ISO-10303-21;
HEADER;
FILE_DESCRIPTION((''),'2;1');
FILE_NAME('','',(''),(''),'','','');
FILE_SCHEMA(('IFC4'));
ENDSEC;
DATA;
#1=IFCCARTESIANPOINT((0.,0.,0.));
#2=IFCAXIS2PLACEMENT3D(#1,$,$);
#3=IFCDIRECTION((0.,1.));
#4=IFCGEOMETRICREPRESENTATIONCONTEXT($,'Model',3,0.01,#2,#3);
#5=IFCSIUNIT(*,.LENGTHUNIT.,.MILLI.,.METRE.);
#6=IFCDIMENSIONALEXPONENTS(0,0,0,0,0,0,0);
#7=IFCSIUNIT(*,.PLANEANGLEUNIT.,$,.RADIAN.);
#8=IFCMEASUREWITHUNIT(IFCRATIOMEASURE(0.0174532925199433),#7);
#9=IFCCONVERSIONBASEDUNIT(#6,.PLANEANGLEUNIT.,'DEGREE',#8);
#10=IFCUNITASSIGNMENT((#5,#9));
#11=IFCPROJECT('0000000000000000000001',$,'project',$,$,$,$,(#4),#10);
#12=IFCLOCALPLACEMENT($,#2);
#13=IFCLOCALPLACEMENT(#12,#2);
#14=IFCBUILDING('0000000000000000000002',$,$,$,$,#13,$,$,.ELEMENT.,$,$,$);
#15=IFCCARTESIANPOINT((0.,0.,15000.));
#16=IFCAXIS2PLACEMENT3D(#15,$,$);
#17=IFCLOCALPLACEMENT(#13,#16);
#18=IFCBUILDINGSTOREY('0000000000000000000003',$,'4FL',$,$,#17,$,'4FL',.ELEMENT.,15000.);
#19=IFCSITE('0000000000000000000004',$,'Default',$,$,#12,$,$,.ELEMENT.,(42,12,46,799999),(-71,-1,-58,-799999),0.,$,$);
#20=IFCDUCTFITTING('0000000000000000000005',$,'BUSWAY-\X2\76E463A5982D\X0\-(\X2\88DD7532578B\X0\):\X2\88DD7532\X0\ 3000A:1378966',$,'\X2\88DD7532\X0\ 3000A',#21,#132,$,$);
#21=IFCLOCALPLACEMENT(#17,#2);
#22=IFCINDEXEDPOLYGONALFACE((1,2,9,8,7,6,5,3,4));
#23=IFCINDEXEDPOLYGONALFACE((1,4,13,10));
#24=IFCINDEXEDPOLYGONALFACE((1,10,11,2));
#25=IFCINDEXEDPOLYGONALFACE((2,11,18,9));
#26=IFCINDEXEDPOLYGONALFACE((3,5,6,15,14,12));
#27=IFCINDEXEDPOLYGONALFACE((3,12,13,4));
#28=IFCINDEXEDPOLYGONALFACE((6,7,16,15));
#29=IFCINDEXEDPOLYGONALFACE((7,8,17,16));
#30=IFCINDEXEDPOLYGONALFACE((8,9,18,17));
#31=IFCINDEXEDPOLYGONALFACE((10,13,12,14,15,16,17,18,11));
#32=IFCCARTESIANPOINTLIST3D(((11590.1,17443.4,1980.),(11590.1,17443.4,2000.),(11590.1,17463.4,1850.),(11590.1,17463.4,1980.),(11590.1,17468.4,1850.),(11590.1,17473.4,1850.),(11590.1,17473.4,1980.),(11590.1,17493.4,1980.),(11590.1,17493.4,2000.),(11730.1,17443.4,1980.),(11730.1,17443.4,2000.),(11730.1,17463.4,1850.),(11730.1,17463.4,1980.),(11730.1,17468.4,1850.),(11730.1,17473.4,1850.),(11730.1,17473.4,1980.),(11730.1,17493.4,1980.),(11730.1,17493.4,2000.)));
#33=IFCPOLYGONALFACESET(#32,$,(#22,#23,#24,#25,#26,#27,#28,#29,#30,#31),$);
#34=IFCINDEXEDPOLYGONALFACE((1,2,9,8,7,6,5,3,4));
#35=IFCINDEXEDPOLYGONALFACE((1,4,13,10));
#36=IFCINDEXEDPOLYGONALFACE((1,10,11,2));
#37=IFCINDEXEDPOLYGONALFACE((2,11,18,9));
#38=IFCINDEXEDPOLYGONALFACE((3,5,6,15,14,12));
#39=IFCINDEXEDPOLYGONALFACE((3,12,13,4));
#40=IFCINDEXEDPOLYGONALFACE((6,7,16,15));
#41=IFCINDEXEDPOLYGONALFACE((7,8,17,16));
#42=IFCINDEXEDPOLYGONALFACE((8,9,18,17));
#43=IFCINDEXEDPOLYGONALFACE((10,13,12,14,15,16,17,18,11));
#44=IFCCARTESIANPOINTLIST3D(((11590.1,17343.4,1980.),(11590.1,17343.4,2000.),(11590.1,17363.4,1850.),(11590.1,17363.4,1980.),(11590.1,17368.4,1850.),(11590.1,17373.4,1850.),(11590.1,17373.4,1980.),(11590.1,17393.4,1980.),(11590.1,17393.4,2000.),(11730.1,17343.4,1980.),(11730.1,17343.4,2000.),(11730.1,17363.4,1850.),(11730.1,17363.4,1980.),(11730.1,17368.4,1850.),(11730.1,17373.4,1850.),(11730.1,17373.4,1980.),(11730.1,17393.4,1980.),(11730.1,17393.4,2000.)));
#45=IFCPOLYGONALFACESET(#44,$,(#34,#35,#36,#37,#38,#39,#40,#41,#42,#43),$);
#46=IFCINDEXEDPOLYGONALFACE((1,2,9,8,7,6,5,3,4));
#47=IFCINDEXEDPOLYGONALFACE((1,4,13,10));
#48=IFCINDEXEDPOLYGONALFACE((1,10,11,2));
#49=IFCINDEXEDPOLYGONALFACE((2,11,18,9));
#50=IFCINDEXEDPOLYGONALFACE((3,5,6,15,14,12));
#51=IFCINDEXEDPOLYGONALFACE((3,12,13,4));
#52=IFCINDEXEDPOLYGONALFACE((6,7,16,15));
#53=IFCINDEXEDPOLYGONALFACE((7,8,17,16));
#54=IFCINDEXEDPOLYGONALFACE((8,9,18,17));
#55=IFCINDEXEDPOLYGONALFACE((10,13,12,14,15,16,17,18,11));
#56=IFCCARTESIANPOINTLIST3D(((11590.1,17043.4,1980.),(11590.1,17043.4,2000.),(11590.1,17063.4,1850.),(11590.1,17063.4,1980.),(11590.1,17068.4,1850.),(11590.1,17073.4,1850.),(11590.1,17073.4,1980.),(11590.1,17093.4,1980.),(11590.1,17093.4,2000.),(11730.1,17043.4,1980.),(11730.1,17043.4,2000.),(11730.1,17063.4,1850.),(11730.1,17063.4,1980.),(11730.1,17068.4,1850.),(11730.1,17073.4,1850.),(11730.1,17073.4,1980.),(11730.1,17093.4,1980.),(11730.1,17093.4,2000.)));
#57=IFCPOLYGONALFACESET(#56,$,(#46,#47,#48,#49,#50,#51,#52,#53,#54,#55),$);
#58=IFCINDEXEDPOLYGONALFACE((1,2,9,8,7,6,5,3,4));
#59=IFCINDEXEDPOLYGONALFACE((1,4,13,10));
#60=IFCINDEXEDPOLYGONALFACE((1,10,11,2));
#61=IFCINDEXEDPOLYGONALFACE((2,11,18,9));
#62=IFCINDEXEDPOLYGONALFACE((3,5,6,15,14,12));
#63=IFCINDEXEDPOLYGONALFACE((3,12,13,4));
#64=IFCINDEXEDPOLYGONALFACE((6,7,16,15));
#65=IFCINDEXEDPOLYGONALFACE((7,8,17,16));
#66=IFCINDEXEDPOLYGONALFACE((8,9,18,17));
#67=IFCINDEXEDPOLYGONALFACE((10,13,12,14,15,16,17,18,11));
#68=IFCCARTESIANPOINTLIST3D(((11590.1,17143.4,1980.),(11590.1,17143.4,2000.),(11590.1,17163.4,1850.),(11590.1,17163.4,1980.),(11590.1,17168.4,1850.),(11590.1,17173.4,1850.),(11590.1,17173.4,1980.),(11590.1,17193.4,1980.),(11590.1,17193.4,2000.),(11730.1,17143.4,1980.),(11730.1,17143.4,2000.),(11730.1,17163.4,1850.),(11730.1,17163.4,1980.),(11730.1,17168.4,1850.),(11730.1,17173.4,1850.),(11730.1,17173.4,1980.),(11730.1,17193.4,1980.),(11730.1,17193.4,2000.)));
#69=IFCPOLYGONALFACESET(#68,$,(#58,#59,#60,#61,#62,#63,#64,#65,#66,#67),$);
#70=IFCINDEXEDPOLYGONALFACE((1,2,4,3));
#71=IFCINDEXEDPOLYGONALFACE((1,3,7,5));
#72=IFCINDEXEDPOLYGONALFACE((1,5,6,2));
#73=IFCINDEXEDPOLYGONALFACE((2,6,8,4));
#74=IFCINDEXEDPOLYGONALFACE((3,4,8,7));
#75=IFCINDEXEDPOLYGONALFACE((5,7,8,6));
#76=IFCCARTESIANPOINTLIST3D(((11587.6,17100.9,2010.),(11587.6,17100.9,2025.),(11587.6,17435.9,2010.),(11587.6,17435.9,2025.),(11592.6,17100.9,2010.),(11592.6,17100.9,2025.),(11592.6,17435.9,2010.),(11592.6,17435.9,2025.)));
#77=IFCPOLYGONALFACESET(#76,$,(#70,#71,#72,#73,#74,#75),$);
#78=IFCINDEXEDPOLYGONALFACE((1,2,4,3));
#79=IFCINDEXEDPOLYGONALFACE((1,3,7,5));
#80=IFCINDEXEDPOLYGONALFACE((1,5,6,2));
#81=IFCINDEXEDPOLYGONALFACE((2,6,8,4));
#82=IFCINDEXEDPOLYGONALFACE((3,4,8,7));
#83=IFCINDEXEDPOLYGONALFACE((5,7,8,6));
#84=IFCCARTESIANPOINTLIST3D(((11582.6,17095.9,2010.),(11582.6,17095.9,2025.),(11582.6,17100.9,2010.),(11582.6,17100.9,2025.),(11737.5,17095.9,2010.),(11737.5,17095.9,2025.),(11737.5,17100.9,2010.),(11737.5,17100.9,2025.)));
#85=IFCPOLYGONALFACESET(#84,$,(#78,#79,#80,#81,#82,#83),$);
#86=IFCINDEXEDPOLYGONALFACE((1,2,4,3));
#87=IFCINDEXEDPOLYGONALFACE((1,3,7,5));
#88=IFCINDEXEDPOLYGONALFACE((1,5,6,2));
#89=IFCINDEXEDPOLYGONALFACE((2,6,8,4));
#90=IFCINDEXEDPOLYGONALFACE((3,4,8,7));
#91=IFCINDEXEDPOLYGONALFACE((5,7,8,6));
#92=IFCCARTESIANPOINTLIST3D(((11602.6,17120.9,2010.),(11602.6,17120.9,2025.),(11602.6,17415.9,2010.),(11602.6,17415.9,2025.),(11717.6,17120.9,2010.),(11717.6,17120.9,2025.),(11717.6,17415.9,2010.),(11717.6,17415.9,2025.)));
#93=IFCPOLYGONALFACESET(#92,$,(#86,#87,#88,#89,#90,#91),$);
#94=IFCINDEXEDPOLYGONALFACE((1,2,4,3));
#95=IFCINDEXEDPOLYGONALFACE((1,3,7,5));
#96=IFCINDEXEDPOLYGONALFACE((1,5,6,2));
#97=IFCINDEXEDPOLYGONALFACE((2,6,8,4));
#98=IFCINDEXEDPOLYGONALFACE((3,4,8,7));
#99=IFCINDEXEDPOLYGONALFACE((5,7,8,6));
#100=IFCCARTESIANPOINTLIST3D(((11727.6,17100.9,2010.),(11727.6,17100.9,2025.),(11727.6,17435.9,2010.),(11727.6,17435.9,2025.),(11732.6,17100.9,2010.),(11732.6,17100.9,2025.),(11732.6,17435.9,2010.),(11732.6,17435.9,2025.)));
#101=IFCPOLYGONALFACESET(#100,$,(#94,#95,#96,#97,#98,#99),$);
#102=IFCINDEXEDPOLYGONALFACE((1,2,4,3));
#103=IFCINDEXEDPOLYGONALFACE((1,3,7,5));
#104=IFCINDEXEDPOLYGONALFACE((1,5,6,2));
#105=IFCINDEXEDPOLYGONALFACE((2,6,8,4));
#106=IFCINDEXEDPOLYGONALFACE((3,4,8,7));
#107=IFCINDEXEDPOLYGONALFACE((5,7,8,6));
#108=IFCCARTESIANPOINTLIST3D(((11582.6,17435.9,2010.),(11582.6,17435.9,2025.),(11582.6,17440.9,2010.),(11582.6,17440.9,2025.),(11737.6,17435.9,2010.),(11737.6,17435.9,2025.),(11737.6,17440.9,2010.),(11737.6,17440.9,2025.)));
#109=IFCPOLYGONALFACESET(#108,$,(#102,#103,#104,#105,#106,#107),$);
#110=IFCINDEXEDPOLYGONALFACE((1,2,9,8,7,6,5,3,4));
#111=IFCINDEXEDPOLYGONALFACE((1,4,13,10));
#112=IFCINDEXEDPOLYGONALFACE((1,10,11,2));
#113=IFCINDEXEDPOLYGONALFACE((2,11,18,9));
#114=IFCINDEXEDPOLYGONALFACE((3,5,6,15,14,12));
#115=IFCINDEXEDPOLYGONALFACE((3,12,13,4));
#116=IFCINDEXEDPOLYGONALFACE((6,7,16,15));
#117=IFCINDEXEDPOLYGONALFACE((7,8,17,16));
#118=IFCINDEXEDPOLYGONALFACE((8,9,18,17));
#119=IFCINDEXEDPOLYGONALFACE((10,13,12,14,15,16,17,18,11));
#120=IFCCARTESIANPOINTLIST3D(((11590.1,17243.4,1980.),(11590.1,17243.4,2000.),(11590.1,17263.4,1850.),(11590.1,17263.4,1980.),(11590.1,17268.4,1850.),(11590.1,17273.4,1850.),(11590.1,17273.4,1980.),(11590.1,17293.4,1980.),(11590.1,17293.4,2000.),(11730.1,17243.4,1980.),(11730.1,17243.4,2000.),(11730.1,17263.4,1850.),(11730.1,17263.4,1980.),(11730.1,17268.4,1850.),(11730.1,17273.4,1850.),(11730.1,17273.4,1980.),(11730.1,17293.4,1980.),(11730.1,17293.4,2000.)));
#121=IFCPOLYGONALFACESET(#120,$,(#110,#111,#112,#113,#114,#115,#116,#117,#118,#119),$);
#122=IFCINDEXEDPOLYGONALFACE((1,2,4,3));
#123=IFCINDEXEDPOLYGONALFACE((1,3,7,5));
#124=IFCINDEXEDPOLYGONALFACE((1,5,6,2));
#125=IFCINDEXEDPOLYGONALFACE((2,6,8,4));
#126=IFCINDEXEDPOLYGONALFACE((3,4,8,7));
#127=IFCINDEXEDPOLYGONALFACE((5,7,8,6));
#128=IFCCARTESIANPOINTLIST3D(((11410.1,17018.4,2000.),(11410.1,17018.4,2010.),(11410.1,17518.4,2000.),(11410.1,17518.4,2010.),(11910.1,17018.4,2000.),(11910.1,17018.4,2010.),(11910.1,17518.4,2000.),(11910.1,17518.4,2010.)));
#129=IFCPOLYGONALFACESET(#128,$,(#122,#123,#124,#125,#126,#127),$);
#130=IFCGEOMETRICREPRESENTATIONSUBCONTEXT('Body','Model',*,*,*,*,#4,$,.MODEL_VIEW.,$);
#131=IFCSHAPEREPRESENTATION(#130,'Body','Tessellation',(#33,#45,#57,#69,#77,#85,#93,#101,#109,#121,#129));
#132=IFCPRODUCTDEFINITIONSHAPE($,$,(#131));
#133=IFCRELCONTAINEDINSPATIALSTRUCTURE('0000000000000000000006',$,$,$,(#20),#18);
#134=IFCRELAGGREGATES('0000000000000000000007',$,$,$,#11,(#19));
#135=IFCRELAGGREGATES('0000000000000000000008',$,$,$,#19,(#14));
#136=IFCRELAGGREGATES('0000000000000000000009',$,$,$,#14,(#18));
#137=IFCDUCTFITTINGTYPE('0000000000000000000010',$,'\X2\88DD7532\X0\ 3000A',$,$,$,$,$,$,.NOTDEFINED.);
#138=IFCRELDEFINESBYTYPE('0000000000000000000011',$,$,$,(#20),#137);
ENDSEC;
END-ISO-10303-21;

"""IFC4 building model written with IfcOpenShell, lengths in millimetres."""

from ifc_helpers import new_model, entity, si_unit, converted_unit, direction, frame, frame_2d, origin, origin_2d_with_axis, place, context, subcontext, project, spatial, polyline, rectangle, outline, extrude, source, transform, mapped, type_object, type_shapes, element, save


model = new_model("IFC4")

# Units and contexts
model_context = context("Model", 3, precision=0.01, world=origin(), true_north=direction((0.0, 1.0)))
body_context = subcontext(model_context, "Body", "Model", "MODEL_VIEW")
ifc_project = project(units=[si_unit("LENGTHUNIT", "METRE", prefix="MILLI"), converted_unit("PLANEANGLEUNIT", "DEGREE", entity("IfcRatioMeasure", 0.0174532925199433), si_unit("PLANEANGLEUNIT", "RADIAN"), dimensions=[0, 0, 0, 0, 0, 0, 0])], contexts=[model_context])

# Site, building, storey
site_placement = place(None, origin())
site = spatial("IfcSite", under=ifc_project, at=site_placement, Name="Default", CompositionType="ELEMENT", RefLatitude=(42, 12, 46, 799999), RefLongitude=(-71, -1, -58, -799999), RefElevation=0.0)
building_placement = place(site_placement, origin())
building = spatial("IfcBuilding", under=site, at=building_placement, CompositionType="ELEMENT")
storey_placement = place(building_placement, frame((0.0, 0.0, 15000.0)))
storey = spatial("IfcBuildingStorey", under=building, at=storey_placement, Name="4FL", LongName="4FL", CompositionType="ELEMENT", Elevation=15000.0)

# Duct fitting
duct_fitting_type_1 = type_object("IfcDuctFittingType", Name="裝甲 3000A", PredefinedType="NOTDEFINED")
shared_shape_1 = source(origin(), body_context, "Body", "SweptSolid", [
    extrude(outline(polyline([(-25.0, -58.9), (25.0, -58.9), (25.0, -38.9), (5.0, -38.9), (5.0, 91.1), (0.0, 91.1), (-5.0, 91.1), (-5.0, -38.9), (-25.0, -38.9), (-25.0, -58.9)])), frame((-200.0, -70.0, -58.9), z_axis=(0.0, 1.0, 0.0), x_axis=(1.0, 0.0, 0.0)), (0.0, 0.0, 1.0), 140.0),
    extrude(outline(polyline([(-25.0, -58.9), (25.0, -58.9), (25.0, -38.9), (5.0, -38.9), (5.0, 91.1), (0.0, 91.1), (-5.0, 91.1), (-5.0, -38.9), (-25.0, -38.9), (-25.0, -58.9)])), frame((-100.0, -70.0, -58.9), z_axis=(0.0, 1.0, 0.0), x_axis=(1.0, 0.0, 0.0)), (0.0, 0.0, 1.0), 140.0),
    extrude(outline(polyline([(-58.9, -25.0), (-38.9, -25.0), (-38.9, -5.0), (91.1, -5.0), (91.1, 0.0), (91.1, 5.0), (-38.9, 5.0), (-38.9, 25.0), (-58.9, 25.0), (-58.9, -25.0)])), frame((200.0, -70.0, -58.9), z_axis=(0.0, 1.0, 0.0), x_axis=(0.0, 0.0, -1.0)), (0.0, 0.0, 1.0), 140.0),
    extrude(outline(polyline([(-58.9, -25.0), (-38.9, -25.0), (-38.9, -5.0), (91.1, -5.0), (91.1, 0.0), (91.1, 5.0), (-38.9, 5.0), (-38.9, 25.0), (-58.9, 25.0), (-58.9, -25.0)])), frame((100.0, -70.0, -58.9), z_axis=(0.0, 1.0, 0.0), x_axis=(0.0, 0.0, -1.0)), (0.0, 0.0, 1.0), 140.0),
    extrude(rectangle(XDim=335.0, YDim=5.0, at=origin_2d_with_axis()), frame((0.0, -70.0, 10.0), z_axis=(0.0, 0.0, 1.0), x_axis=(-1.0, 0.0, 0.0)), (0.0, 0.0, 1.0), 15.0),
    extrude(rectangle(XDim=5.0, YDim=154.9, at=frame_2d((0.0, 0.0), x_axis=(1.0, 0.0))), frame((170.0, -0.1, 10.0), z_axis=(0.0, 0.0, 1.0), x_axis=(-1.0, 0.0, 0.0)), (0.0, 0.0, 1.0), 15.0),
    extrude(rectangle(XDim=295.0, YDim=115.0, at=origin_2d_with_axis()), frame((0.0, 0.0, 10.0), z_axis=(0.0, 0.0, 1.0), x_axis=(-1.0, 0.0, 0.0)), (0.0, 0.0, 1.0), 15.0),
    extrude(rectangle(XDim=335.0, YDim=5.0, at=origin_2d_with_axis()), frame((0.0, 70.0, 10.0), z_axis=(0.0, 0.0, 1.0), x_axis=(-1.0, 0.0, 0.0)), (0.0, 0.0, 1.0), 15.0),
    extrude(rectangle(XDim=5.0, YDim=155.0, at=origin_2d_with_axis()), frame((-170.0, 0.0, 10.0), z_axis=(0.0, 0.0, 1.0), x_axis=(-1.0, 0.0, 0.0)), (0.0, 0.0, 1.0), 15.0),
    extrude(outline(polyline([(-58.9, -25.0), (-38.9, -25.0), (-38.9, -5.0), (91.1, -5.0), (91.1, 0.0), (91.1, 5.0), (-38.9, 5.0), (-38.9, 25.0), (-58.9, 25.0), (-58.9, -25.0)])), frame((0.0, -70.0, -58.9), z_axis=(0.0, 1.0, 0.0), x_axis=(0.0, 0.0, -1.0)), (0.0, 0.0, 1.0), 140.0),
    extrude(rectangle(XDim=500.0, YDim=500.0, at=origin_2d_with_axis()), frame((0.0, 0.0, 0.0), z_axis=(0.0, 0.0, 1.0), x_axis=(0.0, 1.0, 0.0)), (0.0, 0.0, 1.0), 10.0),
])
type_shapes(duct_fitting_type_1, [shared_shape_1])
for number, where, z_axis, x_axis, name in (
    (1, (11660.1, 17268.4, 2000.0), (0.0, 0.0, 1.0), (0.0, -1.0, 0.0), "BUSWAY-盤接頭-(裝甲型):裝甲 3000A:1378966"),
):
    element("IfcDuctFitting", number, at=place(storey_placement, frame(where, z_axis=z_axis, x_axis=x_axis)), inside=storey, type_object=duct_fitting_type_1, Name=name, ObjectType="裝甲 3000A", context=body_context, shape_type="MappedRepresentation", body=[
        mapped(shared_shape_1, transform((0.0, 0.0, 0.0), scale=1.0)),
    ])

save(model, "model.ifc")
